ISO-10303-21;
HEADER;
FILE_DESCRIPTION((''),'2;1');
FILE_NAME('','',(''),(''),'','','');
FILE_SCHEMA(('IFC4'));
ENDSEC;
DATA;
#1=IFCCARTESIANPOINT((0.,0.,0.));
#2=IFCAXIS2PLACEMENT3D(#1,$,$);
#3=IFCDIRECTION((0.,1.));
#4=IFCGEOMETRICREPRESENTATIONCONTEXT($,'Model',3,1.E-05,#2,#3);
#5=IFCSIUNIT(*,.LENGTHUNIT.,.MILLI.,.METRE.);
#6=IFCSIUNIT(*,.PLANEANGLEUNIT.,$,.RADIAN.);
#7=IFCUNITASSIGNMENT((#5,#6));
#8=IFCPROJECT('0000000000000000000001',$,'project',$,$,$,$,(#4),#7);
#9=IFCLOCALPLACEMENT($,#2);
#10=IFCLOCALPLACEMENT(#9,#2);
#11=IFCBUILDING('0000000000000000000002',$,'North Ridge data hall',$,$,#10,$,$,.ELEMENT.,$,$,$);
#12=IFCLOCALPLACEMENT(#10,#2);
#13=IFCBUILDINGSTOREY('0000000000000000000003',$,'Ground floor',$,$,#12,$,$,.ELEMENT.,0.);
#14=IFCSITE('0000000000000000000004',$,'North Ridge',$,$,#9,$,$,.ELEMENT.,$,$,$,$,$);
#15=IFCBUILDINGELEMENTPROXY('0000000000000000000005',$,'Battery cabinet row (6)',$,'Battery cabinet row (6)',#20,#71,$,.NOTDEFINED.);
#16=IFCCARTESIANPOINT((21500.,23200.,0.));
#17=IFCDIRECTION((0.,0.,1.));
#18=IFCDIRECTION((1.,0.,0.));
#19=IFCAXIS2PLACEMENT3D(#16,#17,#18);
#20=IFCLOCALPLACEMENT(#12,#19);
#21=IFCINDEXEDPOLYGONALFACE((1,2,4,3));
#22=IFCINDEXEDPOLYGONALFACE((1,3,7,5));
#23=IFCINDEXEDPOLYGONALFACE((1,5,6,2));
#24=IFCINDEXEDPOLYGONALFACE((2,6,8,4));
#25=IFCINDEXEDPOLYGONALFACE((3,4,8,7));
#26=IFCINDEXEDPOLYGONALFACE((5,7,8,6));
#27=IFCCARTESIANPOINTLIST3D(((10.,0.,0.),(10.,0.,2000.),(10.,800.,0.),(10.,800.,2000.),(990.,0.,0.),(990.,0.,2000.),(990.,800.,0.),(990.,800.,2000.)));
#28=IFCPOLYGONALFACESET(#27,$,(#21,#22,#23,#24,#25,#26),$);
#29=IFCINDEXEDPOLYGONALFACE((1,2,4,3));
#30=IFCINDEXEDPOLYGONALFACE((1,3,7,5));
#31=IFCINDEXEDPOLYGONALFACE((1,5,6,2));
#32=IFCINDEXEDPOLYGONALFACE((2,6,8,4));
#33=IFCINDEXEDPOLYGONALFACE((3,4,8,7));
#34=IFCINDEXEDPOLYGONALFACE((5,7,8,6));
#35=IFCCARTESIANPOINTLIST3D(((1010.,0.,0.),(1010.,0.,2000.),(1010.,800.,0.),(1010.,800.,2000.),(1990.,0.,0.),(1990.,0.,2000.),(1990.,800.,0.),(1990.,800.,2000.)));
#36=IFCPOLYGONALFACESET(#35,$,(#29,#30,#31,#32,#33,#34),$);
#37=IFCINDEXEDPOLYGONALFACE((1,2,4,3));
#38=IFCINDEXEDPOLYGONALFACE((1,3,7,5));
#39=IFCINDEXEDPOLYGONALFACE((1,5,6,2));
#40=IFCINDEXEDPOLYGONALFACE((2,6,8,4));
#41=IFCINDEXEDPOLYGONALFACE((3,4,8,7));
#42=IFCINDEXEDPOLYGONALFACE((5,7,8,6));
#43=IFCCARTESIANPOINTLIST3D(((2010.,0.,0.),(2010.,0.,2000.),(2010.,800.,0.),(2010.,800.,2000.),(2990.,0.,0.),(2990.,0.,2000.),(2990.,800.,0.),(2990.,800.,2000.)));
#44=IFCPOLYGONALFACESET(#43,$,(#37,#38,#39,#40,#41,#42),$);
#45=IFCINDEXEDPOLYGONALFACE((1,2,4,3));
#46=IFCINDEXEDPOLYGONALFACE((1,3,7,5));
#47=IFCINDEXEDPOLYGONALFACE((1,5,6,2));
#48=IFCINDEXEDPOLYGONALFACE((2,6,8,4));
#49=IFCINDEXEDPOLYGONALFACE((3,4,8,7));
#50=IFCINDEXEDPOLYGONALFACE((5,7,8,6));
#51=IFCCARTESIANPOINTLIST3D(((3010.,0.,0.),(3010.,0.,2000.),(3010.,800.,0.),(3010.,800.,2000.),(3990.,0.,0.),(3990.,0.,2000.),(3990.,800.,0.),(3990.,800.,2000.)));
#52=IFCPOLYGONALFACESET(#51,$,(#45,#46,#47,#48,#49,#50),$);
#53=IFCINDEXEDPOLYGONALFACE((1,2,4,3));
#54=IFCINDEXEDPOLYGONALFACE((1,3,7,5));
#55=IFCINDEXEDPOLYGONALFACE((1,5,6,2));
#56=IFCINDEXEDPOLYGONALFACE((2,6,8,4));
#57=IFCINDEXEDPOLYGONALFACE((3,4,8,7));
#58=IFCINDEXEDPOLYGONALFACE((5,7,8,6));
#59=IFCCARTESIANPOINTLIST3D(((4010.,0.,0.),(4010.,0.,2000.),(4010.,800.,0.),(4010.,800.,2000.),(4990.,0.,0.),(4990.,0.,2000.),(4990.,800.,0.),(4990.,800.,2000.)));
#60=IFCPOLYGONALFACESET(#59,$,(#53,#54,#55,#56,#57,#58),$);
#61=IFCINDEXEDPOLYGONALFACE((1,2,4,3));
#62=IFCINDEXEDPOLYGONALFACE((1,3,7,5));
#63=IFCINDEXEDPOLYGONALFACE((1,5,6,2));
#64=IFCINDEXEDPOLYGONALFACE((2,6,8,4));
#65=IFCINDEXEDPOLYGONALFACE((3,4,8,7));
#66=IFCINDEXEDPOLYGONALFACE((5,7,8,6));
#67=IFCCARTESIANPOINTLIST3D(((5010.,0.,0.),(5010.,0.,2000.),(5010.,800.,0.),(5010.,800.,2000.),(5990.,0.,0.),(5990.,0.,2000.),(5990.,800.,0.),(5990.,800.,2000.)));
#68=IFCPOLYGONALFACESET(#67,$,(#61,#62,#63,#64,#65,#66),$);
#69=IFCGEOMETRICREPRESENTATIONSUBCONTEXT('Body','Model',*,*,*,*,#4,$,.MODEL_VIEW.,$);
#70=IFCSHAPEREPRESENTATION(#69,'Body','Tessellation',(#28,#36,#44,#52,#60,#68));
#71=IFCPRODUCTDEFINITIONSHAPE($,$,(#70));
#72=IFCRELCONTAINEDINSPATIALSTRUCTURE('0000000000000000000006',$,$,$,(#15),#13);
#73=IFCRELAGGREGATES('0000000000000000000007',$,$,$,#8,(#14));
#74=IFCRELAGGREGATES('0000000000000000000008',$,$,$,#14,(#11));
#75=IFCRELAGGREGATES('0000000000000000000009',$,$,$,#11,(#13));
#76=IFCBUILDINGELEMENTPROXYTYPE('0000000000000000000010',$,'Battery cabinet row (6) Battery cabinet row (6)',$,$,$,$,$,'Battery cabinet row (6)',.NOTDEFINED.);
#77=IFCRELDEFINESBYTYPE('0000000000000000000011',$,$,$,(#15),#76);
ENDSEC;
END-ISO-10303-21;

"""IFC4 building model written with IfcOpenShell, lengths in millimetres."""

from ifc_helpers import new_model, si_unit, direction, frame, origin, place, context, subcontext, project, spatial, polyline, outline, extrude, source, transform, mapped, type_object, type_shapes, element, save


model = new_model("IFC4")

# Units and contexts
model_context = context("Model", 3, precision=1e-05, world=origin(), true_north=direction((0.0, 1.0)))
body_context = subcontext(model_context, "Body", "Model", "MODEL_VIEW")
ifc_project = project(units=[si_unit("LENGTHUNIT", "METRE", prefix="MILLI"), si_unit("PLANEANGLEUNIT", "RADIAN")], contexts=[model_context])

# Site, building, storey
site_placement = place(None, origin())
site = spatial("IfcSite", under=ifc_project, at=site_placement, Name="North Ridge", CompositionType="ELEMENT")
building_placement = place(site_placement, origin())
building = spatial("IfcBuilding", under=site, at=building_placement, Name="North Ridge data hall", CompositionType="ELEMENT")
storey_placement = place(building_placement, origin())
storey = spatial("IfcBuildingStorey", under=building, at=storey_placement, Name="Ground floor", CompositionType="ELEMENT", Elevation=0.0)

# Building element proxy
building_element_proxy_type_1 = type_object("IfcBuildingElementProxyType", Name="Battery cabinet row (6) Battery cabinet row (6)", ElementType="Battery cabinet row (6)", PredefinedType="NOTDEFINED")
shared_shape_1 = source(origin(), body_context, "Body", "SweptSolid", [
    extrude(outline(polyline([(10.0, 0.0), (990.0, 0.0), (990.0, 800.0), (10.0, 800.0), (10.0, 0.0)])), origin(), (0.0, 0.0, 1.0), 2000.0),
    extrude(outline(polyline([(1010.0, 0.0), (1990.0, 0.0), (1990.0, 800.0), (1010.0, 800.0), (1010.0, 0.0)])), origin(), (0.0, 0.0, 1.0), 2000.0),
    extrude(outline(polyline([(2010.0, 0.0), (2990.0, 0.0), (2990.0, 800.0), (2010.0, 800.0), (2010.0, 0.0)])), origin(), (0.0, 0.0, 1.0), 2000.0),
    extrude(outline(polyline([(3010.0, 0.0), (3990.0, 0.0), (3990.0, 800.0), (3010.0, 800.0), (3010.0, 0.0)])), origin(), (0.0, 0.0, 1.0), 2000.0),
    extrude(outline(polyline([(4010.0, 0.0), (4990.0, 0.0), (4990.0, 800.0), (4010.0, 800.0), (4010.0, 0.0)])), origin(), (0.0, 0.0, 1.0), 2000.0),
    extrude(outline(polyline([(5010.0, 0.0), (5990.0, 0.0), (5990.0, 800.0), (5010.0, 800.0), (5010.0, 0.0)])), origin(), (0.0, 0.0, 1.0), 2000.0),
])
type_shapes(building_element_proxy_type_1, [shared_shape_1])
proxy_placement = place(storey_placement, frame((21500.0, 23200.0, 0.0), z_axis=(0.0, 0.0, 1.0), x_axis=(1.0, 0.0, 0.0)))
element("IfcBuildingElementProxy", 1, at=proxy_placement, inside=storey, type_object=building_element_proxy_type_1, Name="Battery cabinet row (6)", ObjectType="Battery cabinet row (6)", PredefinedType="NOTDEFINED", context=body_context, shape_type="MappedRepresentation", body=[
    mapped(shared_shape_1, transform((0.0, 0.0, 0.0))),
])

save(model, "model.ifc")
